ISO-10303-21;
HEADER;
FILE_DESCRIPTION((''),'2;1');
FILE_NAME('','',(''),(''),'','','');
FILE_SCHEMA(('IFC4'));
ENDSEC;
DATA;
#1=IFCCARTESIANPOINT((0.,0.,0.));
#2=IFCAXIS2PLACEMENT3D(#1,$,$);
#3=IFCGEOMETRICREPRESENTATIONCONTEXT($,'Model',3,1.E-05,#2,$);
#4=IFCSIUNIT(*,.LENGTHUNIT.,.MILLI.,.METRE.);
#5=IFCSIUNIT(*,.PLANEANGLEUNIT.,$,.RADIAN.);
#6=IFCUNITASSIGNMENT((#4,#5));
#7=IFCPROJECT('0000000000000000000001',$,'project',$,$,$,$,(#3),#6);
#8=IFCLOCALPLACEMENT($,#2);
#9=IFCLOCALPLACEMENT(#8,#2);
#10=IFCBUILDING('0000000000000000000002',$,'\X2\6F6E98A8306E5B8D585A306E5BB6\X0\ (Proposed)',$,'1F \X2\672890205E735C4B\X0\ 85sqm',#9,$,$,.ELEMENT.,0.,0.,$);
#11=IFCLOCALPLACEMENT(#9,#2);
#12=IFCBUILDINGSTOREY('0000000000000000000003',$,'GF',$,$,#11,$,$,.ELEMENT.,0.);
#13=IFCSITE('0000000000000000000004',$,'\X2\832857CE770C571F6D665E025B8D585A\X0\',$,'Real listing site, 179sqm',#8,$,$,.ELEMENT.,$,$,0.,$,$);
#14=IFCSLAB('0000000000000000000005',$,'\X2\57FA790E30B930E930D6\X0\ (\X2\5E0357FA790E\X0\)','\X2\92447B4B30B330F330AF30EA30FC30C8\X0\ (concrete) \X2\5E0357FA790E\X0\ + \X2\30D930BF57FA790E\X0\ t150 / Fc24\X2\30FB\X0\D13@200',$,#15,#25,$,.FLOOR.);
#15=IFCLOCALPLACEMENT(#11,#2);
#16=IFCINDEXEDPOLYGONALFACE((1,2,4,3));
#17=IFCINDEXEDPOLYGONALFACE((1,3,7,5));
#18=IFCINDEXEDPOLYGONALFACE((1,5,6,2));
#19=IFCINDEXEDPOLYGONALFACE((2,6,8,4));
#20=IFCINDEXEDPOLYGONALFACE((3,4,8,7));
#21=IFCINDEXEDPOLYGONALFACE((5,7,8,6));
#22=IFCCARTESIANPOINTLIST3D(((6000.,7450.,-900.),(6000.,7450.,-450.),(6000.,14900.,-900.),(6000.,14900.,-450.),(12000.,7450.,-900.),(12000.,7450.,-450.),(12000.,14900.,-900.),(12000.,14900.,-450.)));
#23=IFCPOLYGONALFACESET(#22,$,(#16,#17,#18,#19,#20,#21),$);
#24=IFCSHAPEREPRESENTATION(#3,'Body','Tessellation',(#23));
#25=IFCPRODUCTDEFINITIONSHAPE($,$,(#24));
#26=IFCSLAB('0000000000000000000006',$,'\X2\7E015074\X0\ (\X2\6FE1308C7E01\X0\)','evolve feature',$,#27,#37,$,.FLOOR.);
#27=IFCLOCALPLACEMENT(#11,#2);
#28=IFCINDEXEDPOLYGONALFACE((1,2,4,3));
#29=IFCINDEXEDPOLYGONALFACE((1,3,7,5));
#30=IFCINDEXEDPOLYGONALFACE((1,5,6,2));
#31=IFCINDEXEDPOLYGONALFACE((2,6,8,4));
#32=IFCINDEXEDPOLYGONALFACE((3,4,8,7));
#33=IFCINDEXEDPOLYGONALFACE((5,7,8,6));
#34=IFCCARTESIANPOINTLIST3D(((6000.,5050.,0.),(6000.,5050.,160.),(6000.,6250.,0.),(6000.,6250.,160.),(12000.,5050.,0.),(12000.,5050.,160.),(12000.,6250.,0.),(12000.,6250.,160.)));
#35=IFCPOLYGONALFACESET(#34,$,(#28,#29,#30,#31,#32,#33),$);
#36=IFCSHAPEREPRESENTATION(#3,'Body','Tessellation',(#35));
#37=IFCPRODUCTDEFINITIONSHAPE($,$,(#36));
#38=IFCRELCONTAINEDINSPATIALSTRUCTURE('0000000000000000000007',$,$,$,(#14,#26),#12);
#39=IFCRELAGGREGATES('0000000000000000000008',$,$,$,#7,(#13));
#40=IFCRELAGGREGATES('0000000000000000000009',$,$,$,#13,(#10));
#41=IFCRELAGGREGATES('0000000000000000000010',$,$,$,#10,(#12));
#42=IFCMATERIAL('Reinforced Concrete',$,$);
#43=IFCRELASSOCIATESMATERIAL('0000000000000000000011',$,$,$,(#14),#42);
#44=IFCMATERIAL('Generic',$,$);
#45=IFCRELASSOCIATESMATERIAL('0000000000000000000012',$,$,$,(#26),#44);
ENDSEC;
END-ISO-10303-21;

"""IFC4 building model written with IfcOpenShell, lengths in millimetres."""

from ifc_helpers import new_model, si_unit, frame, frame_2d, origin, place, context, project, spatial, rectangle, extrude, material, element, save


model = new_model("IFC4")

# Units and contexts
model_context = context("Model", 3, precision=1e-05, world=origin())
ifc_project = project(units=[si_unit("LENGTHUNIT", "METRE", prefix="MILLI"), si_unit("PLANEANGLEUNIT", "RADIAN")], contexts=[model_context])

# Site, building, storey
site_placement = place(None, origin())
site = spatial("IfcSite", under=ifc_project, at=site_placement, Name="茨城県土浦市宍塚", ObjectType="Real listing site, 179sqm", CompositionType="ELEMENT", RefElevation=0.0)
building_placement = place(site_placement, origin())
building = spatial("IfcBuilding", under=site, at=building_placement, Name="潮風の宍塚の家 (Proposed)", ObjectType="1F 木造平屋 85sqm", CompositionType="ELEMENT", ElevationOfRefHeight=0.0, ElevationOfTerrain=0.0)
storey_placement = place(building_placement, origin())
storey = spatial("IfcBuildingStorey", under=building, at=storey_placement, Name="GF", CompositionType="ELEMENT", Elevation=0.0)

# Slabs
ifc_material_1 = material(Name="Reinforced Concrete")
slab_1_placement = place(storey_placement, frame((3000.0, 3725.0, -450.0)))
element("IfcSlab", 1, at=slab_1_placement, inside=storey, material=ifc_material_1, Name="基礎スラブ (布基礎)", Description="鉄筋コンクリート (concrete) 布基礎 + ベタ基礎 t150 / Fc24・D13@200", PredefinedType="FLOOR", context=model_context, shape_type="SweptSolid", body=[
    extrude(rectangle(XDim=6000.0, YDim=7450.0, at=frame_2d((3000.0, 3725.0))), frame((3000.0, 3725.0, -450.0)), (0.0, 0.0, 1.0), 450.0),
])
ifc_material_2 = material(Name="Generic")
slab_2_placement = place(storey_placement, frame((3000.0, 2525.0, 0.0)))
element("IfcSlab", 2, at=slab_2_placement, inside=storey, material=ifc_material_2, Name="縁側 (濡れ縁)", Description="evolve feature", PredefinedType="FLOOR", context=model_context, shape_type="SweptSolid", body=[
    extrude(rectangle(XDim=6000.0, YDim=1200.0, at=frame_2d((3000.0, 600.0))), frame((3000.0, 2525.0, 0.0)), (0.0, 0.0, 1.0), 160.0),
])

save(model, "model.ifc")
